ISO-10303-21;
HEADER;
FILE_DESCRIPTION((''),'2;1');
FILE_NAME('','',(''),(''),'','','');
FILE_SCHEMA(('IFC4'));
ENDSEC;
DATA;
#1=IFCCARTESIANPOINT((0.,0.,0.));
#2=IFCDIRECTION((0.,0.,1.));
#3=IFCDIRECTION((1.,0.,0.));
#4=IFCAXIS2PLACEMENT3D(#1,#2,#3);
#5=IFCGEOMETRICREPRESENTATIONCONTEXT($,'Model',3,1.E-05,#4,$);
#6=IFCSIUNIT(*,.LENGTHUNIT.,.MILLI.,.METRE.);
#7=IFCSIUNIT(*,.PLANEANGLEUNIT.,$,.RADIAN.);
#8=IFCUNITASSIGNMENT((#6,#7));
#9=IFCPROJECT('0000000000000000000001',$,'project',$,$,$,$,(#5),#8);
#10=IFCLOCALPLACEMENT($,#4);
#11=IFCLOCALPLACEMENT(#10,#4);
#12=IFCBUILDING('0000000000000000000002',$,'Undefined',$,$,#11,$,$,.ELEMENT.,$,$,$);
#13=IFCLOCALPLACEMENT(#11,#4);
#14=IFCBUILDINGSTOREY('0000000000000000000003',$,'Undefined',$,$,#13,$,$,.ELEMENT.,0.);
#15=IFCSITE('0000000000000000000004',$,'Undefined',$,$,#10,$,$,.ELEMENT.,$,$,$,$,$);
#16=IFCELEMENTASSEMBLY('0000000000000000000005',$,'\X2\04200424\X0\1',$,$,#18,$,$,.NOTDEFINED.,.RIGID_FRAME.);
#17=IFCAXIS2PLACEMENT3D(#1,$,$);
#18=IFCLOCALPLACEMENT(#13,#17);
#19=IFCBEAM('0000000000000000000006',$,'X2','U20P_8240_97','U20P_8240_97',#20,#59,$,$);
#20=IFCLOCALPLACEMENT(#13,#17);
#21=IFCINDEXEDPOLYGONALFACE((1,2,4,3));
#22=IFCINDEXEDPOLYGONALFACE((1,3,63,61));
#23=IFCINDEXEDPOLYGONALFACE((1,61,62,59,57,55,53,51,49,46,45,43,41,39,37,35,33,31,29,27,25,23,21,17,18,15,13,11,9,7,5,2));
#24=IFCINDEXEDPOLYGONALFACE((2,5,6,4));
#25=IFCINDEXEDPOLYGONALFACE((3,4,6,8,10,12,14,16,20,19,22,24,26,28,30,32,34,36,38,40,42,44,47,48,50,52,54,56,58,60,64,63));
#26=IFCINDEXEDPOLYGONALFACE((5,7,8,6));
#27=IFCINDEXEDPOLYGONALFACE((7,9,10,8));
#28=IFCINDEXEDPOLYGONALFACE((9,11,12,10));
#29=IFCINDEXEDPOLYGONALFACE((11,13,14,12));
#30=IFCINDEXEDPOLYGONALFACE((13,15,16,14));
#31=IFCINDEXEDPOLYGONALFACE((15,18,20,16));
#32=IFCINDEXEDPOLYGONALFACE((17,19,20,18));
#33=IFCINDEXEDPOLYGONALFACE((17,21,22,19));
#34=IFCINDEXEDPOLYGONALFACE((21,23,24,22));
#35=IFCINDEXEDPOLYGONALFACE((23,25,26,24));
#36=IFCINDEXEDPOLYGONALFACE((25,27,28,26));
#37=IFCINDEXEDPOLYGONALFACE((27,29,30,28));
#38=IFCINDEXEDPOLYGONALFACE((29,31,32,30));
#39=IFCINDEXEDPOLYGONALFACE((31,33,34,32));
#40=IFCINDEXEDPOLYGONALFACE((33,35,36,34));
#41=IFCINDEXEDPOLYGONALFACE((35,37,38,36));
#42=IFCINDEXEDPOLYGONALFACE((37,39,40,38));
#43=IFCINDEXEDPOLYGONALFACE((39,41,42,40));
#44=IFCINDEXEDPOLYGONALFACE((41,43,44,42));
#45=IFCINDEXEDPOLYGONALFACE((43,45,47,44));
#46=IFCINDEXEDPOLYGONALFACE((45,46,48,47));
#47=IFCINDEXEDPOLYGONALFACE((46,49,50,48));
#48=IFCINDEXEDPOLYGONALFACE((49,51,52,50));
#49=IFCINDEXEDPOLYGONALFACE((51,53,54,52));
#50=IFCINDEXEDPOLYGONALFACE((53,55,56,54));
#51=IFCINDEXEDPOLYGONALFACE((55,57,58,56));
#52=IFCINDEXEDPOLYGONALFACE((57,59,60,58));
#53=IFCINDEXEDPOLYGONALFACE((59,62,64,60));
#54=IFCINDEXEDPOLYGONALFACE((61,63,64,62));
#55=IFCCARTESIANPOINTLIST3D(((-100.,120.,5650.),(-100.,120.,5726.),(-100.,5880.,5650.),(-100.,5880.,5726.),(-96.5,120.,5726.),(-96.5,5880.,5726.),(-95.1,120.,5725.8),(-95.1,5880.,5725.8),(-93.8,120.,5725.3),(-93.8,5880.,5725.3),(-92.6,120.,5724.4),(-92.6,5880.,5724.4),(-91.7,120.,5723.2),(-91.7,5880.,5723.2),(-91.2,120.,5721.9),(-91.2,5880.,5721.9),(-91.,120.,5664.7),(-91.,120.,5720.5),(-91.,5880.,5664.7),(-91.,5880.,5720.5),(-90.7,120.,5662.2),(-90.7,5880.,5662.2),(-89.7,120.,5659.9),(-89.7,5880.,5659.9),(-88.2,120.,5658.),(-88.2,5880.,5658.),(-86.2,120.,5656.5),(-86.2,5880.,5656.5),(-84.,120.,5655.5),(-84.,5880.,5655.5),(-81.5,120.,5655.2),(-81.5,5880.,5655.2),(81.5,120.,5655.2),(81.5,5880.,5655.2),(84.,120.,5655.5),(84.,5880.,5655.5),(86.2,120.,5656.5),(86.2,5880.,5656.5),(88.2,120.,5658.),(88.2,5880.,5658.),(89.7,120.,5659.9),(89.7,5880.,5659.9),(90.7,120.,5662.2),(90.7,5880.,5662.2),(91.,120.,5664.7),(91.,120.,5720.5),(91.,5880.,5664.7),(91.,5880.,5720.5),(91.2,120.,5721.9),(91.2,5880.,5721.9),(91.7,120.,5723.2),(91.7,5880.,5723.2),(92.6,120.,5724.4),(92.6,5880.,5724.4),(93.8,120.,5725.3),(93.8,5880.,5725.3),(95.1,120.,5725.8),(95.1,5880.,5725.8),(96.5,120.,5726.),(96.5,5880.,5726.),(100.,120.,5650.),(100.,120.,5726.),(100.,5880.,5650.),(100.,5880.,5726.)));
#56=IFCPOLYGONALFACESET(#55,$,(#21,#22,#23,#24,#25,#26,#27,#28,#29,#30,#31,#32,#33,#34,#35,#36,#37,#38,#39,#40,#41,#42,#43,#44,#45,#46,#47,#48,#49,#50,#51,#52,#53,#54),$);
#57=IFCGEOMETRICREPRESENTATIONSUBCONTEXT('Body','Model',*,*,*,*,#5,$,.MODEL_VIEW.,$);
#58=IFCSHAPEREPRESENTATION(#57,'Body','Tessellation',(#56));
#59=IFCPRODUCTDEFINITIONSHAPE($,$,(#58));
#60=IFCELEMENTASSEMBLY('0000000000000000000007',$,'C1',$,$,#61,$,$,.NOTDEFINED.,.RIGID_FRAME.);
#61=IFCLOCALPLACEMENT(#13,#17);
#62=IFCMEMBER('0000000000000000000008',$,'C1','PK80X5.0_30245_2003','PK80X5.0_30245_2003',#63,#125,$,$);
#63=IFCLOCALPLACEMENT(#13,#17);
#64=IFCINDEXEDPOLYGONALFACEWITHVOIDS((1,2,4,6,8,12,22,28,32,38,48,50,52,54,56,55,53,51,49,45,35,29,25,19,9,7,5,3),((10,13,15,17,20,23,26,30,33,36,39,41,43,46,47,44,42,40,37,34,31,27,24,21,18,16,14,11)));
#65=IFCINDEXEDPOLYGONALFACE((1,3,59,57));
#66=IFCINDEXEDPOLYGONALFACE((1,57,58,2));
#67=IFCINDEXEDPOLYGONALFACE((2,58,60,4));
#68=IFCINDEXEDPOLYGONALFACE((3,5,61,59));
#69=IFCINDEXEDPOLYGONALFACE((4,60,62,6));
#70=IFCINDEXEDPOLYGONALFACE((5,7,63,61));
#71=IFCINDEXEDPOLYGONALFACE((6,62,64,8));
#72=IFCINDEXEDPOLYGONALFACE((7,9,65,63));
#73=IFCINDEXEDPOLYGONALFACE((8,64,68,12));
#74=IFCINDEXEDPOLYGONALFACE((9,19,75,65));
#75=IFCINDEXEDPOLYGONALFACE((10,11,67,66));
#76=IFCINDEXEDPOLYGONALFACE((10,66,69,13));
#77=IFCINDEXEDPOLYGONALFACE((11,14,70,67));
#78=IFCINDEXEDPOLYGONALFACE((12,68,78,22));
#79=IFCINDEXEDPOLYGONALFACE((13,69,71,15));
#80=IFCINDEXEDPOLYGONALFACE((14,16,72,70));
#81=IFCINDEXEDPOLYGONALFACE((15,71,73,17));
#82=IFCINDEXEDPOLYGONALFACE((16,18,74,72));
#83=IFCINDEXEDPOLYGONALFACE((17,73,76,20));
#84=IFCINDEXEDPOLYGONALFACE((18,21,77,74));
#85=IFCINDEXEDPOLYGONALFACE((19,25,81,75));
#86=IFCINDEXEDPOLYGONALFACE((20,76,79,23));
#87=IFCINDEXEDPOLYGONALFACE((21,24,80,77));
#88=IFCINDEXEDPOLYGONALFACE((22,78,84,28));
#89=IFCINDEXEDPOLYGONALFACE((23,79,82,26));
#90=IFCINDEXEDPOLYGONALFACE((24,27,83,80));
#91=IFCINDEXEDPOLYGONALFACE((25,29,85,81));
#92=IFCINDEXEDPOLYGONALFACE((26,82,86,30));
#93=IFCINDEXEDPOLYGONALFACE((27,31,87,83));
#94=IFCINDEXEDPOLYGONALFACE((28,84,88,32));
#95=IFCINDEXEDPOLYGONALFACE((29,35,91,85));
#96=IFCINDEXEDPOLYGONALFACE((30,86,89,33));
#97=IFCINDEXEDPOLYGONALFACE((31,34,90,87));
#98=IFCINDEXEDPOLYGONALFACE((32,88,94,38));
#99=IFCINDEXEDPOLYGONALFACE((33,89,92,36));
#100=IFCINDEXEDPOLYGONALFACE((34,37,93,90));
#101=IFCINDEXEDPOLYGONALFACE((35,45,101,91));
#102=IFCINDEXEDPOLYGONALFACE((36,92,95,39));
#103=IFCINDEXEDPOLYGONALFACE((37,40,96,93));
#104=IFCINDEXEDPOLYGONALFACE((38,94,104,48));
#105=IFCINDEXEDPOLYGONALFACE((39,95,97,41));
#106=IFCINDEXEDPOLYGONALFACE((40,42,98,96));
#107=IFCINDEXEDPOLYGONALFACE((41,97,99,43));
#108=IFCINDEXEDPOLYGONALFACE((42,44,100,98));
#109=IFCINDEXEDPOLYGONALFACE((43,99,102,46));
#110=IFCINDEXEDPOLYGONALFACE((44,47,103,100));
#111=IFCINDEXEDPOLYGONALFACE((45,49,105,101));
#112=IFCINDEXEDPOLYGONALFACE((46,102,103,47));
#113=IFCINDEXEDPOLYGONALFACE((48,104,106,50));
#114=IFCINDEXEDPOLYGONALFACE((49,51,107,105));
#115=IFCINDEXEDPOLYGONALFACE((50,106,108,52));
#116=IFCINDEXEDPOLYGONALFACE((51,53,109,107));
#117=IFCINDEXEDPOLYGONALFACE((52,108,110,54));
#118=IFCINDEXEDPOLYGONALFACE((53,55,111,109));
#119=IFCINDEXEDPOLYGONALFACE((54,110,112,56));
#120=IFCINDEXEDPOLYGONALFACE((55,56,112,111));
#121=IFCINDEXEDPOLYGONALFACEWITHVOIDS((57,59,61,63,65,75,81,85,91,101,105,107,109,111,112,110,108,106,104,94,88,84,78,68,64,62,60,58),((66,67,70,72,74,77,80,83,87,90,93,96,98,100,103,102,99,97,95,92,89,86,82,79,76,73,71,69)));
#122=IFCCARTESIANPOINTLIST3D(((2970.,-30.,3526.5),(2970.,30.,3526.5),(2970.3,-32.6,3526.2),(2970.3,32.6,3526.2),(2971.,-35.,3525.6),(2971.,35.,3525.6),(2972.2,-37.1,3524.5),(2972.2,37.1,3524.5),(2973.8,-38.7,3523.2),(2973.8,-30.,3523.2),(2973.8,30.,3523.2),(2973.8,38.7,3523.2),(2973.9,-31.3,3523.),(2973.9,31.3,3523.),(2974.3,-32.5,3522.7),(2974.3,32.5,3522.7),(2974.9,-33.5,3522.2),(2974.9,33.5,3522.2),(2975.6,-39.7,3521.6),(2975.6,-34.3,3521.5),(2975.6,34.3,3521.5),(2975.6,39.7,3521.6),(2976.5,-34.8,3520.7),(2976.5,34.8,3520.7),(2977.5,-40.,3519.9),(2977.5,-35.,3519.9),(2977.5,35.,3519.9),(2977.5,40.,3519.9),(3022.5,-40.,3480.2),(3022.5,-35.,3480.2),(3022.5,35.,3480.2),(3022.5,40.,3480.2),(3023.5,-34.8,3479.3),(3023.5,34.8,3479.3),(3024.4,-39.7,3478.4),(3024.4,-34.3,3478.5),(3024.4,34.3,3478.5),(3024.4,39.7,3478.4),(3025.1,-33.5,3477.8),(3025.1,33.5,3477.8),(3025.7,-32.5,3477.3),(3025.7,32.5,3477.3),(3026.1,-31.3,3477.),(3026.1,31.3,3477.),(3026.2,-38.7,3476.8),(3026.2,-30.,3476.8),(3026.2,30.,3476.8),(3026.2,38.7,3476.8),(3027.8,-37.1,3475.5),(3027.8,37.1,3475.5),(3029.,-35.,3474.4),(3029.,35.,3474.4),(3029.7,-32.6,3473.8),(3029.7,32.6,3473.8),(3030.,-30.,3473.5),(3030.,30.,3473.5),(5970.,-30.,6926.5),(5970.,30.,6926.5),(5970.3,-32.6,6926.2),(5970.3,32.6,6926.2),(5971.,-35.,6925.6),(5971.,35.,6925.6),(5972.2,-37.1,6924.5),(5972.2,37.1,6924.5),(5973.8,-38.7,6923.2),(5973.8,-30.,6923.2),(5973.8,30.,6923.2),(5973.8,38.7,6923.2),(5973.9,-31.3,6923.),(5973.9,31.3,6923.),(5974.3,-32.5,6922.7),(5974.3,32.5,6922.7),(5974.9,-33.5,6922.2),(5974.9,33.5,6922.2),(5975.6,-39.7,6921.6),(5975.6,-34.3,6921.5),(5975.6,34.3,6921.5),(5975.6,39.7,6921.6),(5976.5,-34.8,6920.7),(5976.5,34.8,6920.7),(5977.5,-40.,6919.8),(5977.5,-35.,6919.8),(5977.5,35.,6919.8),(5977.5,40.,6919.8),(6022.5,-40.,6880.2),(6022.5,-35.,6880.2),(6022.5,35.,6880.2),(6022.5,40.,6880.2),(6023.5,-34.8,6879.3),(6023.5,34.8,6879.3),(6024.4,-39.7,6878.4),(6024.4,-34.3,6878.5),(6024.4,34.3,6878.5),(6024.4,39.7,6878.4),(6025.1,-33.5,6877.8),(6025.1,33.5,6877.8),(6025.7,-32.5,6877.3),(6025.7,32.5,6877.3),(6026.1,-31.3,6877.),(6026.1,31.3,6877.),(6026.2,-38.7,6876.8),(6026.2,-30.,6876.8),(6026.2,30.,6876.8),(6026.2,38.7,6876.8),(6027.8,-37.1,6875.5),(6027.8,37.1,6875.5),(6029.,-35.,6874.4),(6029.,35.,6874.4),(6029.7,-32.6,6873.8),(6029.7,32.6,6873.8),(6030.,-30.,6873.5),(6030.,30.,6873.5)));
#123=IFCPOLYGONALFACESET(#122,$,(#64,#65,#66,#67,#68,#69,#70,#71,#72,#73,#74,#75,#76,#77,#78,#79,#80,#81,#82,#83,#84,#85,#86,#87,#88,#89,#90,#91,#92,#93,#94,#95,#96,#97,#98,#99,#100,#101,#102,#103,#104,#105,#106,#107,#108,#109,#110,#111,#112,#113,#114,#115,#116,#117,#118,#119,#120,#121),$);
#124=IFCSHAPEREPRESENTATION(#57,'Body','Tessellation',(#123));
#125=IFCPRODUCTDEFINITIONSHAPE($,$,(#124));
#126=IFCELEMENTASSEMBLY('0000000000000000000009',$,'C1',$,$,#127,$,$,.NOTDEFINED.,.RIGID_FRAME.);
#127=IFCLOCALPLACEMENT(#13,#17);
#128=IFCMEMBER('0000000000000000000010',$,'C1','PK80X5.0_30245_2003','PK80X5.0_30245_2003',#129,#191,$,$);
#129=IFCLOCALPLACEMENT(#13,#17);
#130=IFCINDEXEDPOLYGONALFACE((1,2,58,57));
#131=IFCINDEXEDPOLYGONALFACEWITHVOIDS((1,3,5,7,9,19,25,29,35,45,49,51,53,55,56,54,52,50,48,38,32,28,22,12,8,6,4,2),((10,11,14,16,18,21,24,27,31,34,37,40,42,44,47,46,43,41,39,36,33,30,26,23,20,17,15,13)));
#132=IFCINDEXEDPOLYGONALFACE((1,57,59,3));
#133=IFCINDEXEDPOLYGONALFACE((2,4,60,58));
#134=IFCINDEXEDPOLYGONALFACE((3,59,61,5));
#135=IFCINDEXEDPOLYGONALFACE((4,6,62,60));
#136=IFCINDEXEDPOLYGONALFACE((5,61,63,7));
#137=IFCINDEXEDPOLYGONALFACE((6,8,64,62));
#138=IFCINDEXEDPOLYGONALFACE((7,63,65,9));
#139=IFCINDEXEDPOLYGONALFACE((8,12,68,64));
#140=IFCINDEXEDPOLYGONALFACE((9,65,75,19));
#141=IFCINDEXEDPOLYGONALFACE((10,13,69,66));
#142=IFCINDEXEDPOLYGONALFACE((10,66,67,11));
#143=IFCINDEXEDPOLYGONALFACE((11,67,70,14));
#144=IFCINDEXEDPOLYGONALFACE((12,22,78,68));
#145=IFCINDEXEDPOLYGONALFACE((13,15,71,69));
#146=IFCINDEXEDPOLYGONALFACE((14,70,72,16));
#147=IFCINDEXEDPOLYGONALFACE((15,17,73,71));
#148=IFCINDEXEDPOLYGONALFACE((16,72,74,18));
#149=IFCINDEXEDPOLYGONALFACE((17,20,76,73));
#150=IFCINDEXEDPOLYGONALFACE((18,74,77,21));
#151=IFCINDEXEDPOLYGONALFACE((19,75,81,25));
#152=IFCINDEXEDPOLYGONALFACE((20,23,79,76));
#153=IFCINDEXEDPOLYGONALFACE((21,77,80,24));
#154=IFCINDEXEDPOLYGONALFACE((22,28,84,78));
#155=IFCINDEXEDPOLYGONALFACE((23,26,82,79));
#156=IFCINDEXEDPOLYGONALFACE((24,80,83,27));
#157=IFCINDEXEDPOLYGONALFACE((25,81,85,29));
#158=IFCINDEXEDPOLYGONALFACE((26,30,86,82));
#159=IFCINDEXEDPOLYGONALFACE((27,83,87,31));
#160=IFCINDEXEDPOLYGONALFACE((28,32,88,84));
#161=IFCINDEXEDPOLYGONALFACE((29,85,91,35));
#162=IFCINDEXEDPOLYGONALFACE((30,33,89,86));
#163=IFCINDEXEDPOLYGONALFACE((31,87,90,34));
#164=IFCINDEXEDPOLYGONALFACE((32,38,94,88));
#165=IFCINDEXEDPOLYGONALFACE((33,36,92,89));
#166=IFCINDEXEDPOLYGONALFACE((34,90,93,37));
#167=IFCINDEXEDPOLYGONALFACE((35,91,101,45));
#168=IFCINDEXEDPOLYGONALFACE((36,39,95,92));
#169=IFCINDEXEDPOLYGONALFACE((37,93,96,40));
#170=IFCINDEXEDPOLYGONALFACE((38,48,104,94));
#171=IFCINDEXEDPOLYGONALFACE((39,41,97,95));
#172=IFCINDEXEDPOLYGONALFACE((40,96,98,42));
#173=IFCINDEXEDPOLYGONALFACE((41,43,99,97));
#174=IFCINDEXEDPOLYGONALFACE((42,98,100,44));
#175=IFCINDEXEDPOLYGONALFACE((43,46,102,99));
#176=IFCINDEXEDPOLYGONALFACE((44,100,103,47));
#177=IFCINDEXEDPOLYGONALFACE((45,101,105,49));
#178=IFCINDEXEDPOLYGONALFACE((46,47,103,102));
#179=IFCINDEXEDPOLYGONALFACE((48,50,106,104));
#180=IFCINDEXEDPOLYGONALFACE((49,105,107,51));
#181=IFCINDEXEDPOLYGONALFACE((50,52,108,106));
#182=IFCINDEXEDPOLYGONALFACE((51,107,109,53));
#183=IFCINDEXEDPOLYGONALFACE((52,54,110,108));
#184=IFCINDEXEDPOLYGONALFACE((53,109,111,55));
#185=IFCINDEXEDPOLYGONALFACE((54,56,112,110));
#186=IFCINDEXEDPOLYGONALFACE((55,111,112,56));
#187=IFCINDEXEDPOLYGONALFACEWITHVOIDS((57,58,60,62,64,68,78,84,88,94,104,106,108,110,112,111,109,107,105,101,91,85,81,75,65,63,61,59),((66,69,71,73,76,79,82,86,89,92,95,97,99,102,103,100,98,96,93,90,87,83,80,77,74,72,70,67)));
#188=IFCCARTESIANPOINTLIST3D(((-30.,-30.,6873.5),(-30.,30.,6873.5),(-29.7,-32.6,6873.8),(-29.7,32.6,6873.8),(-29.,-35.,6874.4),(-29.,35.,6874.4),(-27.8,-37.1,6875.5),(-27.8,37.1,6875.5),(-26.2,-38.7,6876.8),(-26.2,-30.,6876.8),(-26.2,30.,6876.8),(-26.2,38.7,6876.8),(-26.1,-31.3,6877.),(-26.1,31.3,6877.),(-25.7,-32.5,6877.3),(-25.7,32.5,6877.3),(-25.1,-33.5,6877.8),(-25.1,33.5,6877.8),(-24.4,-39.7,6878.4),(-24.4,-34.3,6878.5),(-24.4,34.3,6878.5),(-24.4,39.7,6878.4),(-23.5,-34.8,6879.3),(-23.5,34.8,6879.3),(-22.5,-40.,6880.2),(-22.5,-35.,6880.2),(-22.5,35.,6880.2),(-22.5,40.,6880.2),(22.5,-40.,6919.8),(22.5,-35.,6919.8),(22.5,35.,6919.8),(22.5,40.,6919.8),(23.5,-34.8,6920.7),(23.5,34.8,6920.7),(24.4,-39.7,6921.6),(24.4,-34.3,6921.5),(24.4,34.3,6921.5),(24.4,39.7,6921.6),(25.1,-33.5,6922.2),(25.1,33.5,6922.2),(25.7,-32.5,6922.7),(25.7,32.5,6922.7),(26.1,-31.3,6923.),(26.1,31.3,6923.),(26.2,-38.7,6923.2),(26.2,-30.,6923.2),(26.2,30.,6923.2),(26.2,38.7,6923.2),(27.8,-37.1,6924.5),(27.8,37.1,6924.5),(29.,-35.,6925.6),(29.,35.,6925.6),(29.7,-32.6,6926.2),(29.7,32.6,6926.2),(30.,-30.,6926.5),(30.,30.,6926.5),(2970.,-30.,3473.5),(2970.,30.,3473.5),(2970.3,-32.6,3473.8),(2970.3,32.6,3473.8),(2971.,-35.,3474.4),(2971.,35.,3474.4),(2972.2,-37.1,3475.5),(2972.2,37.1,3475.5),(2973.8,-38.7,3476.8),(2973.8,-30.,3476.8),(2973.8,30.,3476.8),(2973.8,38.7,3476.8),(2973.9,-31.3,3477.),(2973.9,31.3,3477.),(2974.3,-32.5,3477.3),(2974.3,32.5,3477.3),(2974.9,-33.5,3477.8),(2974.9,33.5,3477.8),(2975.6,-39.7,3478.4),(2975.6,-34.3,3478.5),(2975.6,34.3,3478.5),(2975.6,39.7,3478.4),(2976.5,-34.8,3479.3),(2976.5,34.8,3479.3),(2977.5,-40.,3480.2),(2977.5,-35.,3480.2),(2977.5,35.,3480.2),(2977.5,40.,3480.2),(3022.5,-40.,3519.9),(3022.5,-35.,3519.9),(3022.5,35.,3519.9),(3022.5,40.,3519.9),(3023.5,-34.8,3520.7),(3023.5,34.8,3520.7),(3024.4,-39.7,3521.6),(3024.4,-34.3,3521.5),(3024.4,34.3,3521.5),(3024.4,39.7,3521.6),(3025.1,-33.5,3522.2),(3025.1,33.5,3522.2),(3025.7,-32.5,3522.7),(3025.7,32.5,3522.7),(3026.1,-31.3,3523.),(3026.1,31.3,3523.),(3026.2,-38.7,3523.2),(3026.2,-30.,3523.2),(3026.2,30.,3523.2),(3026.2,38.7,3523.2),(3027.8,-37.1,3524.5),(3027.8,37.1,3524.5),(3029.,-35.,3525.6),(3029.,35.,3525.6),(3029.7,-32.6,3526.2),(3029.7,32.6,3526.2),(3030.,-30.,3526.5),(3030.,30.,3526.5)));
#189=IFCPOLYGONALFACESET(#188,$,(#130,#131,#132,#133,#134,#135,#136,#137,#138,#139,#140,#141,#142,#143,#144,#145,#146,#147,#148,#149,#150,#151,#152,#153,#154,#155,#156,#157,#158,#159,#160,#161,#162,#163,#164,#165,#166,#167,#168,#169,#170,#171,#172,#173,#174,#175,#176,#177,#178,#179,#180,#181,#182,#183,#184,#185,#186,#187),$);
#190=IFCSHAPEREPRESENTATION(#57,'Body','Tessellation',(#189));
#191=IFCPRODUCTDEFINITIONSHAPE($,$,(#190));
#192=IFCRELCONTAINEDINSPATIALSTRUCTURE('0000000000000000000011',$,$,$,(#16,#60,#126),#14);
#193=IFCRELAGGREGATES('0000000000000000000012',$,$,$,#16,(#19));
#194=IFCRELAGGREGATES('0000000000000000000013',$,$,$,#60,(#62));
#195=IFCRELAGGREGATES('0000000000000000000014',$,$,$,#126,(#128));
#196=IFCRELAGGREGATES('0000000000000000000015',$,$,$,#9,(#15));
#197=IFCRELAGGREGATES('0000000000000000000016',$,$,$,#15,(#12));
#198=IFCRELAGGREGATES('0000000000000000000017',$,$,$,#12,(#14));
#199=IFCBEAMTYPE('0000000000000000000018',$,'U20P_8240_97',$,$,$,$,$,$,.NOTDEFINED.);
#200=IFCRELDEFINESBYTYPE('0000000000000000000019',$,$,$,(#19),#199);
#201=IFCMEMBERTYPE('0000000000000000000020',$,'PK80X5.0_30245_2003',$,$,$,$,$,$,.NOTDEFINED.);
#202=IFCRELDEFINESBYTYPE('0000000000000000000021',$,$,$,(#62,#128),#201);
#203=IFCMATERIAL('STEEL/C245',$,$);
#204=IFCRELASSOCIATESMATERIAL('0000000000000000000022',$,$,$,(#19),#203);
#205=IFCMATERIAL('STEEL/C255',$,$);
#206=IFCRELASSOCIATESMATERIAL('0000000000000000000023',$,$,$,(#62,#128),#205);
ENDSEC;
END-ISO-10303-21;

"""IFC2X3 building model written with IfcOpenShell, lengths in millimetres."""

from ifc_helpers import new_model, si_unit, frame, origin_with_axes, origin_2d_with_axis, place, context, subcontext, project, spatial, hollow_rectangle, u_section, extrude, material, type_object, element, aggregate, save


model = new_model("IFC2X3")

# Units and contexts
model_context = context("Model", 3, precision=1e-05, world=origin_with_axes())
body_context = subcontext(model_context, "Body", "Model", "MODEL_VIEW")
ifc_project = project(units=[si_unit("LENGTHUNIT", "METRE", prefix="MILLI"), si_unit("PLANEANGLEUNIT", "RADIAN")], contexts=[model_context])

# Site, building, storey
site_placement = place(None, origin_with_axes())
site = spatial("IfcSite", under=ifc_project, at=site_placement, Name="Undefined", CompositionType="ELEMENT")
building_placement = place(site_placement, origin_with_axes())
building = spatial("IfcBuilding", under=site, at=building_placement, Name="Undefined", CompositionType="ELEMENT")
storey_placement = place(building_placement, origin_with_axes())
storey = spatial("IfcBuildingStorey", under=building, at=storey_placement, Name="Undefined", CompositionType="ELEMENT", Elevation=0.0)

# Shared definitions
ifc_material_1 = material(Name="STEEL/C245")

# Element assembly, beam
ifc_material_2 = material(Name="STEEL/C255")
assembly_1_placement = place(storey_placement, origin_with_axes())
assembly_1 = element("IfcElementAssembly", 1, at=assembly_1_placement, inside=storey, Name="РФ1", AssemblyPlace="NOTDEFINED", PredefinedType="RIGID_FRAME")
beam_type_1 = type_object("IfcBeamType", Name="U20P_8240_97", PredefinedType="NOTDEFINED")
beam_1_placement = place(assembly_1_placement, frame((0.0, 120.0, 5688.0), z_axis=(-1.0, 0.0, 0.0), x_axis=(0.0, 1.0, 0.0)))
beam_1 = element("IfcBeam", 2, at=beam_1_placement, type_object=beam_type_1, material=ifc_material_1, Name="X2", Description="U20P_8240_97", ObjectType="U20P_8240_97", context=body_context, shape_type="SweptSolid", body=[
    extrude(u_section(Depth=200.0, FlangeWidth=76.0, WebThickness=5.2, FlangeThickness=9.0, FilletRadius=9.5, EdgeRadius=5.5, at=origin_2d_with_axis()), frame((5760.0, 0.0, 0.0), z_axis=(-1.0, 0.0, 0.0), x_axis=(0.0, -1.0, 0.0)), (0.0, 0.0, 1.0), 5760.0),
])
aggregate(assembly_1, [beam_1])

# Element assemblies, members
assembly_2_placement = place(storey_placement, origin_with_axes())
assembly_2 = element("IfcElementAssembly", 3, at=assembly_2_placement, inside=storey, Name="C1", AssemblyPlace="NOTDEFINED", PredefinedType="RIGID_FRAME")
member_type = type_object("IfcMemberType", Name="PK80X5.0_30245_2003", PredefinedType="NOTDEFINED")
member_1_placement = place(assembly_2_placement, frame((3000.0, 0.0, 3500.0), z_axis=(0.749838, 0.0, -0.661622), x_axis=(0.661622, 0.0, 0.749838)))
member_1 = element("IfcMember", 4, at=member_1_placement, type_object=member_type, material=ifc_material_2, Name="C1", Description="PK80X5.0_30245_2003", ObjectType="PK80X5.0_30245_2003", context=body_context, shape_type="SweptSolid", body=[
    extrude(hollow_rectangle(XDim=80.0, YDim=80.0, WallThickness=5.0, InnerFilletRadius=5.0, OuterFilletRadius=10.0, at=origin_2d_with_axis()), frame((4534.3, 0.0, 0.0), z_axis=(-1.0, 0.0, 0.0), x_axis=(0.0, -1.0, 0.0)), (0.0, 0.0, 1.0), 4534.3),
])
aggregate(assembly_2, [member_1])
assembly_3_placement = place(storey_placement, origin_with_axes())
assembly_3 = element("IfcElementAssembly", 5, at=assembly_3_placement, inside=storey, Name="C1", AssemblyPlace="NOTDEFINED", PredefinedType="RIGID_FRAME")
member_2_placement = place(assembly_3_placement, frame((3000.0, 0.0, 3500.0), z_axis=(-0.749838, 0.0, -0.661622), x_axis=(-0.661622, 0.0, 0.749838)))
member_2 = element("IfcMember", 6, at=member_2_placement, type_object=member_type, material=ifc_material_2, Name="C1", Description="PK80X5.0_30245_2003", ObjectType="PK80X5.0_30245_2003", context=body_context, shape_type="SweptSolid", body=[
    extrude(hollow_rectangle(XDim=80.0, YDim=80.0, WallThickness=5.0, InnerFilletRadius=5.0, OuterFilletRadius=10.0, at=origin_2d_with_axis()), frame((4534.3, 0.0, 0.0), z_axis=(-1.0, 0.0, 0.0), x_axis=(0.0, -1.0, 0.0)), (0.0, 0.0, 1.0), 4534.3),
])
aggregate(assembly_3, [member_2])

save(model, "model.ifc")
